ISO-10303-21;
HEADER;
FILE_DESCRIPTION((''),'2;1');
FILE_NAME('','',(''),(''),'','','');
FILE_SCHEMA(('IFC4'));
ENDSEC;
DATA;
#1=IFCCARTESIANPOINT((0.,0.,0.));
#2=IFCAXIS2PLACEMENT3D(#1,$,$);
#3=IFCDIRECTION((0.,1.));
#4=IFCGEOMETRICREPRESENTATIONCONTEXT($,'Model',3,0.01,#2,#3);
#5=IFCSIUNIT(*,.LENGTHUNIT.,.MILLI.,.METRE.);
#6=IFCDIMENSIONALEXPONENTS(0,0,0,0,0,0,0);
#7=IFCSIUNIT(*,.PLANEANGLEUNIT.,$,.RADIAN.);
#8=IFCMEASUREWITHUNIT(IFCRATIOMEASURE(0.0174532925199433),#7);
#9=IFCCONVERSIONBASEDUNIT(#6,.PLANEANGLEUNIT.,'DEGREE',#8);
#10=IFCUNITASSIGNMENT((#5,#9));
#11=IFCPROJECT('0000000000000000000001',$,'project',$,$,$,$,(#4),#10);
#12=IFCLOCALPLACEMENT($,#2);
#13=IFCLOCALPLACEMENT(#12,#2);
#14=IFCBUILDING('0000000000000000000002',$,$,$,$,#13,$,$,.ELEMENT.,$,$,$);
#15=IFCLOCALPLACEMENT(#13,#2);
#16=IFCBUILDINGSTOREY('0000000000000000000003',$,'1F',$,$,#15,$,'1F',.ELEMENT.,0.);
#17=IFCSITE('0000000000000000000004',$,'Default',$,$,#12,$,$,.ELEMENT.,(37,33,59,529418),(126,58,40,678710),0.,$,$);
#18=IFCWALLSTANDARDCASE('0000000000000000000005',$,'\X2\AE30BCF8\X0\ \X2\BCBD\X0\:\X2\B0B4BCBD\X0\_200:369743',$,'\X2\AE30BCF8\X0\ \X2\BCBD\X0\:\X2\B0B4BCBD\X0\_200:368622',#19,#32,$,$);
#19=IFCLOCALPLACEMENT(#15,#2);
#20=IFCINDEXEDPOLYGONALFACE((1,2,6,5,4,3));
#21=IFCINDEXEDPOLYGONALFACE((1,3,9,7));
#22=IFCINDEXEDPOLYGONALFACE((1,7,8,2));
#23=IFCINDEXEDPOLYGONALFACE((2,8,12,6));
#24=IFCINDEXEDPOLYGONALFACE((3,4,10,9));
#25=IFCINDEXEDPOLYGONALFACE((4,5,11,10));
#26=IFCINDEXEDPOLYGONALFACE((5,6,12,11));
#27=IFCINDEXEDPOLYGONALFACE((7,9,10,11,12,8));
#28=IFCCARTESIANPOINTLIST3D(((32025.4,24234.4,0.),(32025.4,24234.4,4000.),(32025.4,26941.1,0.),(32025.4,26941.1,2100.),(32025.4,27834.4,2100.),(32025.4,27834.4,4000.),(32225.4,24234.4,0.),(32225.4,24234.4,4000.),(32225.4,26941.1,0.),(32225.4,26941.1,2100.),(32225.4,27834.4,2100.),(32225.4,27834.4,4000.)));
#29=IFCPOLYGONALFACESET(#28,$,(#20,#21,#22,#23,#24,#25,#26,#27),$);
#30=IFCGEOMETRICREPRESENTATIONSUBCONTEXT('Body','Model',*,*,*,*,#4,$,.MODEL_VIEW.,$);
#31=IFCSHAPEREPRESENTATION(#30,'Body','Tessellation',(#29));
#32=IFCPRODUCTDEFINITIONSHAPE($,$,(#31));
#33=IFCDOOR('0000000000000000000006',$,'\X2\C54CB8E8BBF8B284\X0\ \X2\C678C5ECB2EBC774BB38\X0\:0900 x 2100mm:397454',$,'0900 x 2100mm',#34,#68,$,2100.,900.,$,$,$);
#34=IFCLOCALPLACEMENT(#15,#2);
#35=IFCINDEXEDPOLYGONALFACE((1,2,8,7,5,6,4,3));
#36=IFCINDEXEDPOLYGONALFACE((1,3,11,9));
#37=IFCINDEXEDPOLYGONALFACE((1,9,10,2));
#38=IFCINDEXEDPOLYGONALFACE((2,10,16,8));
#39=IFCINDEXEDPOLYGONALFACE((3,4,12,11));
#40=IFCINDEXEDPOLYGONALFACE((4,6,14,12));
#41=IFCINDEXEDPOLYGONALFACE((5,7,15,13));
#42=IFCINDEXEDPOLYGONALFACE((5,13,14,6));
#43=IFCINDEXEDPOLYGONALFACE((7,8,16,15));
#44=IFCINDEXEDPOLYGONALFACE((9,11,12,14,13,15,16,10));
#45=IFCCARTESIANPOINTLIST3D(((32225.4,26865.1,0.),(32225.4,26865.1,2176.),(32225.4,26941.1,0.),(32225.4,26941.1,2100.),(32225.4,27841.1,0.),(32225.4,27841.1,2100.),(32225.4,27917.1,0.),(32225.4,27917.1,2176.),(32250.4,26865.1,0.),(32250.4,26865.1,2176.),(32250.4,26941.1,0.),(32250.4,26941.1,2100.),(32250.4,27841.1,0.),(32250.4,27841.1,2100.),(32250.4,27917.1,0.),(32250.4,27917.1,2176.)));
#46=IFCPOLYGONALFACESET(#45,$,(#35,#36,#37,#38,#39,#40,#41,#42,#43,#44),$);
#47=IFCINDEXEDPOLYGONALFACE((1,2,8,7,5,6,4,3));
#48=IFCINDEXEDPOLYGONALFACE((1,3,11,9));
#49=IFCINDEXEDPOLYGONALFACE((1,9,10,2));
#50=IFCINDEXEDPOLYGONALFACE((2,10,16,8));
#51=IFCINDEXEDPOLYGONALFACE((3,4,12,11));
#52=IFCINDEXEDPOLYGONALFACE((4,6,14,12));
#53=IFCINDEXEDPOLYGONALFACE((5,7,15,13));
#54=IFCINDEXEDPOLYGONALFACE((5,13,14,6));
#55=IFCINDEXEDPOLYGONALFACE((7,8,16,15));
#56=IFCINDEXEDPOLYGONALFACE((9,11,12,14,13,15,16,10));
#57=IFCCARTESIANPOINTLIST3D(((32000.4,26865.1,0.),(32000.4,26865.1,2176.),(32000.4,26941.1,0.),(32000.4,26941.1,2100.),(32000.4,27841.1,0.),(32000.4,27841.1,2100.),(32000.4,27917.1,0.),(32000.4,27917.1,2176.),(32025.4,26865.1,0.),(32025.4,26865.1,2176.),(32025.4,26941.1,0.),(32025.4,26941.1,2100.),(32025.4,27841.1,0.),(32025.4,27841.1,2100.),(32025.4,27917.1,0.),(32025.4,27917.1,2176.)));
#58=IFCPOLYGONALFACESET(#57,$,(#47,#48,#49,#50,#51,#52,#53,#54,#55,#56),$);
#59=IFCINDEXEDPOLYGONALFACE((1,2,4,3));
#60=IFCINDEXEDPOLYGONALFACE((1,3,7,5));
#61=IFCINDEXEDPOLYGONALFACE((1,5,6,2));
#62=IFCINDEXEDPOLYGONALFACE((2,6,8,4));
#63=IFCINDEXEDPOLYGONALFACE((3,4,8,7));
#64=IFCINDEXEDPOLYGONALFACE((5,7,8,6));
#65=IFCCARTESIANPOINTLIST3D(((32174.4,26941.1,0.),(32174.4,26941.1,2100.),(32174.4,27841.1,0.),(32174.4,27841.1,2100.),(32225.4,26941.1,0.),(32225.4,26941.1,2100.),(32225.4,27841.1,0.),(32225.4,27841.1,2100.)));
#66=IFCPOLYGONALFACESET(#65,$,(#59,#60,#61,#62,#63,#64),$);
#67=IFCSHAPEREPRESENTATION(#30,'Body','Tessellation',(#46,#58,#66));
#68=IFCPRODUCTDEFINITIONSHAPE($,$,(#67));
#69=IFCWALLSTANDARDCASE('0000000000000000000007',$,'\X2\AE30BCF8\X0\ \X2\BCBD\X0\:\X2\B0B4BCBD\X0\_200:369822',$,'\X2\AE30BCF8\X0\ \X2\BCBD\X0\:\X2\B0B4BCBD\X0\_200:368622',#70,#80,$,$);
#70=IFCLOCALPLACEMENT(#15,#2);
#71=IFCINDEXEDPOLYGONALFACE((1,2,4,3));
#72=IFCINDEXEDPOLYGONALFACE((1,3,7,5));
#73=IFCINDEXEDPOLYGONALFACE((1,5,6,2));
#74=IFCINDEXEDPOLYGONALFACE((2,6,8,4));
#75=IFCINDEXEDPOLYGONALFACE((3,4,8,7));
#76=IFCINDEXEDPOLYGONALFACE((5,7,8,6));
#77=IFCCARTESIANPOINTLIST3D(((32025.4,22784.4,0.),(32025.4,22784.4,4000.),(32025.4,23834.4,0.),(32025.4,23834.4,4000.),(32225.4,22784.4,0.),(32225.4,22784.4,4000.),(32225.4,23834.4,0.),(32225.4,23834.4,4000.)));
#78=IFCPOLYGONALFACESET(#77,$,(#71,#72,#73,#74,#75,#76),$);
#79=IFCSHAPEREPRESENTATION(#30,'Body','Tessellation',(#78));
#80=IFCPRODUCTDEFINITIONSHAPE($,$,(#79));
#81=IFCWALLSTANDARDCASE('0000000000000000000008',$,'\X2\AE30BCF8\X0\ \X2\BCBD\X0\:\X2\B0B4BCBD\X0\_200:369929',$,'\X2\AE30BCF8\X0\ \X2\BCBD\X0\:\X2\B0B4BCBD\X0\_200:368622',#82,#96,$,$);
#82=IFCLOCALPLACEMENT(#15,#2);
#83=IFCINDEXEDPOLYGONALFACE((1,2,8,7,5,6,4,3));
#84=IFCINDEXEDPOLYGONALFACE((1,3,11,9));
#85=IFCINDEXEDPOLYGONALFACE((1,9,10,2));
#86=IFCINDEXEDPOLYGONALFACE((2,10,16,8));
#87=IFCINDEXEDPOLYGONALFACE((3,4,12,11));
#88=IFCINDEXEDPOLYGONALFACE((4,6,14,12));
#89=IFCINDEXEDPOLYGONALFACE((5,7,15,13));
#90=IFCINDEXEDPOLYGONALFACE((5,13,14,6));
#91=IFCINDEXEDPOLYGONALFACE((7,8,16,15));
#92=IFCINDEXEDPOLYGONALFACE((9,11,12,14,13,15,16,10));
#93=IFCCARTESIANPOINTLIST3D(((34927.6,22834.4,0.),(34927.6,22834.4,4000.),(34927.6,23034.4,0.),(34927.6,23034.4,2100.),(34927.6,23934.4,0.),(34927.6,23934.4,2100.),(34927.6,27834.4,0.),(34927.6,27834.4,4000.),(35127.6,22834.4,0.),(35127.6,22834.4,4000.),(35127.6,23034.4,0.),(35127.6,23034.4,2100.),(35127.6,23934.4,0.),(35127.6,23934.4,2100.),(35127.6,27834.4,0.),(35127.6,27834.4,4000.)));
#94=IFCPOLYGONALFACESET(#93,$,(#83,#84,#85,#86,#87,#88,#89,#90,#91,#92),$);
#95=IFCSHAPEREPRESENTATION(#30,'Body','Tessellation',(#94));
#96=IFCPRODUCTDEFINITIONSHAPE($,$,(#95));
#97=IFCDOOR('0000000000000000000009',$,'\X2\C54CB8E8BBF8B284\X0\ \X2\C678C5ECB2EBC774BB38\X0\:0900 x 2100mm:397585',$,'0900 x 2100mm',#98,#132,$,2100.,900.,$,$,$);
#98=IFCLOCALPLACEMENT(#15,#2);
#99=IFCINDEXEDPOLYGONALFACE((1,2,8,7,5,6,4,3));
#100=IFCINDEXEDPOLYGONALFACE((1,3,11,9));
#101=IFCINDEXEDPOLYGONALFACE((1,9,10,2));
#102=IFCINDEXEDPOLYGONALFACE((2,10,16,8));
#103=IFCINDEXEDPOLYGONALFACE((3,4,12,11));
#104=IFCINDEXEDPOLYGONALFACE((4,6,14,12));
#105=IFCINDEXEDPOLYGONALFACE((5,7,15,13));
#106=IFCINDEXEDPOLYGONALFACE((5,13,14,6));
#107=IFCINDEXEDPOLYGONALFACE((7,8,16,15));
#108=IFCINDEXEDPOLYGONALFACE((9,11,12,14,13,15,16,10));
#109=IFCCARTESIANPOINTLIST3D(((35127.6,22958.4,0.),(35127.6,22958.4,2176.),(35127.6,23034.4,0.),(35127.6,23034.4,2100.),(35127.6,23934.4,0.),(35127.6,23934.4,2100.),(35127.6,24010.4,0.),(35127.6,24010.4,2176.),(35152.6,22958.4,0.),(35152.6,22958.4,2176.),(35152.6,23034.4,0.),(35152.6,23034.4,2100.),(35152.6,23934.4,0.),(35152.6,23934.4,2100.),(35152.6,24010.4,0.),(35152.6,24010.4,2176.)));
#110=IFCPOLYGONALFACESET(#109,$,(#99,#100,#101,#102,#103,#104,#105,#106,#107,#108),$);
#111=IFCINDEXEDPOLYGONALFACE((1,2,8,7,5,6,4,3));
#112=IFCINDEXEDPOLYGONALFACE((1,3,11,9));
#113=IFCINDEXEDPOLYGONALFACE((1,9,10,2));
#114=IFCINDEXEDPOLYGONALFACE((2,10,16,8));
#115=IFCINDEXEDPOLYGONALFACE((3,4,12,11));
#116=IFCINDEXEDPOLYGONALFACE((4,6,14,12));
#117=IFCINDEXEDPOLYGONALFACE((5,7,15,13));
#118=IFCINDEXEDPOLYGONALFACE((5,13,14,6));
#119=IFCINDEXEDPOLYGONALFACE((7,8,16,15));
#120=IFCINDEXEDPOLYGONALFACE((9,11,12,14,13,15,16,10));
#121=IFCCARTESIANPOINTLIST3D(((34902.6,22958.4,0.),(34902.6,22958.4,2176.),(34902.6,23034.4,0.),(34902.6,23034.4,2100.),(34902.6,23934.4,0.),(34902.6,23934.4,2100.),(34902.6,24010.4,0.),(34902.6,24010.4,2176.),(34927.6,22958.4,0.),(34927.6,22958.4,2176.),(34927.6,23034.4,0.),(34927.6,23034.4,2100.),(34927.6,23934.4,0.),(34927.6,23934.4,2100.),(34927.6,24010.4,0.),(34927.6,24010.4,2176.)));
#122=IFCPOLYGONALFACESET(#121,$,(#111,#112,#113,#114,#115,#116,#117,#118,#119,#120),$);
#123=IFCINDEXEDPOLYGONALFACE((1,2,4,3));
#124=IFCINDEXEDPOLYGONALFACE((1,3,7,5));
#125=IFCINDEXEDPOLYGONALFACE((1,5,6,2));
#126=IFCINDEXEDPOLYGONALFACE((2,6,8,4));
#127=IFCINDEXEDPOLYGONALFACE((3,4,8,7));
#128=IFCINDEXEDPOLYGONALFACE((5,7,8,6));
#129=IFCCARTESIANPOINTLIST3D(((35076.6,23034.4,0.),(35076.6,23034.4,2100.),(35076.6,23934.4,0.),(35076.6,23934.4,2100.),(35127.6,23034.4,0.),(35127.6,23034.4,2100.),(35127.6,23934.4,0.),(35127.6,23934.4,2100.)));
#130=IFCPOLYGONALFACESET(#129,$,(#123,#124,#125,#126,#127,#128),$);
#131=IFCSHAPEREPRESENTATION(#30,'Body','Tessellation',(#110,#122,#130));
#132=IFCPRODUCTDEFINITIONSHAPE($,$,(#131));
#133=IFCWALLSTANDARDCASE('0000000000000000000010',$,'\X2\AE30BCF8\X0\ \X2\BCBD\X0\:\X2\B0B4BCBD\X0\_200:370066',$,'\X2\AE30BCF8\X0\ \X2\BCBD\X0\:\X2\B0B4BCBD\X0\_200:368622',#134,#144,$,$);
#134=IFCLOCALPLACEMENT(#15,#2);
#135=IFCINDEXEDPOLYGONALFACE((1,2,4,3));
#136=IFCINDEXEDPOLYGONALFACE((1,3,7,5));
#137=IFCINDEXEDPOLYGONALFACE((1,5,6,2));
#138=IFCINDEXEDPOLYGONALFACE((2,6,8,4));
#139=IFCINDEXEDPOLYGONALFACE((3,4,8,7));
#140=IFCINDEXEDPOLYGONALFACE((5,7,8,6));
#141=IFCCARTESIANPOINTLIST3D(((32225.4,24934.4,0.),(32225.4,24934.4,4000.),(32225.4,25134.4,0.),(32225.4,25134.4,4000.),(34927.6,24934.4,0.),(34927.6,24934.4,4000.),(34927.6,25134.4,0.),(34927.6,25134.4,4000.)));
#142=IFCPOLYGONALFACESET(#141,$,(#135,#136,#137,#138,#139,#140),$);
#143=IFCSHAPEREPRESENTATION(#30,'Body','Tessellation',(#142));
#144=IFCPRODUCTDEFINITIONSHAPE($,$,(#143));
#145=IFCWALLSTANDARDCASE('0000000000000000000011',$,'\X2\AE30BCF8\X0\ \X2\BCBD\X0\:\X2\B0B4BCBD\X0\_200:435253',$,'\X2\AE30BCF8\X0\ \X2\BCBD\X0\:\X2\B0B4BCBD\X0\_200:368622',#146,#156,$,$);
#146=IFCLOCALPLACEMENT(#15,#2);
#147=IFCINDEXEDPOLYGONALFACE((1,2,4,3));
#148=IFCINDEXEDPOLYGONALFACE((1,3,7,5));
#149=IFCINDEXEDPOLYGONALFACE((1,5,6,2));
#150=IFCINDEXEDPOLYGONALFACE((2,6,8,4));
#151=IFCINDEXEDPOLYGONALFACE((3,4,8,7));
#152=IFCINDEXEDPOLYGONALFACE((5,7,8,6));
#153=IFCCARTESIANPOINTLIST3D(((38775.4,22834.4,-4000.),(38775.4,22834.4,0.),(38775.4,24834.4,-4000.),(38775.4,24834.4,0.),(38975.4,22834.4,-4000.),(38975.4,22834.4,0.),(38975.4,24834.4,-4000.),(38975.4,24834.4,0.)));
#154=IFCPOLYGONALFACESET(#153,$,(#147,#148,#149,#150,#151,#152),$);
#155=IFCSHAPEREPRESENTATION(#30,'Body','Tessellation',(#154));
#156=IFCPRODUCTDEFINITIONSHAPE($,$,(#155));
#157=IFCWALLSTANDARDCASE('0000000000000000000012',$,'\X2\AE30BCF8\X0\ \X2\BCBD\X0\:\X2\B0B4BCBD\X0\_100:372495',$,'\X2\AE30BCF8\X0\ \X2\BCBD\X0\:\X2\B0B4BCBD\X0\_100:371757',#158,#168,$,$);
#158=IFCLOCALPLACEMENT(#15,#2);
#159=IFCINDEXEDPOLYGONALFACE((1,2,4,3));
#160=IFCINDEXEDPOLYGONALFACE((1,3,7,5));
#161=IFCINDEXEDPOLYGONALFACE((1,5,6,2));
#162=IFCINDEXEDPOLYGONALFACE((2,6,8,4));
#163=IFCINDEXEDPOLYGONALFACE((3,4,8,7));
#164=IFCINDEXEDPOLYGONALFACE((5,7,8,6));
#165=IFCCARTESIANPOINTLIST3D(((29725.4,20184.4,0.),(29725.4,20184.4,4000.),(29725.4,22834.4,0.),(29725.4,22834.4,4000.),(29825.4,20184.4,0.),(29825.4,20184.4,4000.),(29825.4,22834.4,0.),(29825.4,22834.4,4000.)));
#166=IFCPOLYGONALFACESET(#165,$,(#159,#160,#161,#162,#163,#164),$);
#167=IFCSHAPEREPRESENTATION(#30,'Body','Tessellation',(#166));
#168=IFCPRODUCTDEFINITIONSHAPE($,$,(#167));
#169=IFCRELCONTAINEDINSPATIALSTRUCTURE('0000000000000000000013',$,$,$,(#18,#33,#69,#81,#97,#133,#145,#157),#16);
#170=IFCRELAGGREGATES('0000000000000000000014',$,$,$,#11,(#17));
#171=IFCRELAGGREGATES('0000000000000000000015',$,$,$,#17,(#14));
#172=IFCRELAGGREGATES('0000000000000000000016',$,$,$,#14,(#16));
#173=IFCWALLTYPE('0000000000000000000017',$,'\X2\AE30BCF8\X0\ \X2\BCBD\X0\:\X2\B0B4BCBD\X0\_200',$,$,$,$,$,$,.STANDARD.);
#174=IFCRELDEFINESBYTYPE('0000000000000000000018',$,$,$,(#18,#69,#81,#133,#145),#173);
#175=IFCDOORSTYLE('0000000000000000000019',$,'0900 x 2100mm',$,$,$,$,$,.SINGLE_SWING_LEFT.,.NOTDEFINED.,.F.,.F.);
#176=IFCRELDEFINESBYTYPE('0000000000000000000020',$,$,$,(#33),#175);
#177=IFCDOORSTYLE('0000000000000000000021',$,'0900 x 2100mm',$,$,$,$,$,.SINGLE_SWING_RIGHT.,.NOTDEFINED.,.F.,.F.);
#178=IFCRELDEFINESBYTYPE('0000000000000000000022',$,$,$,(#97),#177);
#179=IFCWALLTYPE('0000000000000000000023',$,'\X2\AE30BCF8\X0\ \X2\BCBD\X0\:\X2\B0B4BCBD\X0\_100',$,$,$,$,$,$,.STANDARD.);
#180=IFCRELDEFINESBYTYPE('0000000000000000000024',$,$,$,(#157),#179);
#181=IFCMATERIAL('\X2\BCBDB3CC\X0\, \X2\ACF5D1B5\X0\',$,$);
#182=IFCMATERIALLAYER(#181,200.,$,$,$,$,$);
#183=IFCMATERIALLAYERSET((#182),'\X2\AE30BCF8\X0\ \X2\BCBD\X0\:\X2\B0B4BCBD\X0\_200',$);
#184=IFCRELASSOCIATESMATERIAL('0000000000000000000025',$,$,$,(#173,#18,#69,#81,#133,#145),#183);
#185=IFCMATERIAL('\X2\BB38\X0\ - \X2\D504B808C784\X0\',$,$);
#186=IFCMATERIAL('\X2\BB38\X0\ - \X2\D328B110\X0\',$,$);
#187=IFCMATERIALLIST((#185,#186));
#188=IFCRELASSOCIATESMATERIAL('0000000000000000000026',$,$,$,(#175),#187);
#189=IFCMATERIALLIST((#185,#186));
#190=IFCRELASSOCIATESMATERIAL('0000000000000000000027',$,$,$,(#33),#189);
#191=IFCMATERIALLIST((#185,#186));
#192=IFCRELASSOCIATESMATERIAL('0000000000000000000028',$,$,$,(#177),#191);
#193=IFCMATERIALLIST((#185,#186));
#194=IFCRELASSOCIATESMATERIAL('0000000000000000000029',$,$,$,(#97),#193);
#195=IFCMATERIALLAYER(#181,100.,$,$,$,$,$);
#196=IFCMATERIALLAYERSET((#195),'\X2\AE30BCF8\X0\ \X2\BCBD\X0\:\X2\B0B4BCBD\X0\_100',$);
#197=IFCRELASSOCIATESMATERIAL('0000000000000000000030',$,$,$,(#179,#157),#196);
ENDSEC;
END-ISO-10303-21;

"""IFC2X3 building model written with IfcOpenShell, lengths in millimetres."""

from ifc_helpers import new_model, entity, si_unit, converted_unit, direction, frame, frame_2d, origin, place, context, subcontext, project, spatial, polyline, rectangle, outline, extrude, source, transform, mapped, material, material_list, layer, layer_set, layer_usage, type_object, type_shapes, element, fill, save


model = new_model("IFC2X3")

# Units and contexts
model_context = context("Model", 3, precision=0.01, world=origin(), true_north=direction((0.0, 1.0)))
body_context = subcontext(model_context, "Body", "Model", "MODEL_VIEW")
ifc_project = project(units=[si_unit("LENGTHUNIT", "METRE", prefix="MILLI"), converted_unit("PLANEANGLEUNIT", "DEGREE", entity("IfcRatioMeasure", 0.0174532925199433), si_unit("PLANEANGLEUNIT", "RADIAN"), dimensions=[0, 0, 0, 0, 0, 0, 0])], contexts=[model_context])

# Site, building, storey
site_placement = place(None, origin())
site = spatial("IfcSite", under=ifc_project, at=site_placement, Name="Default", CompositionType="ELEMENT", RefLatitude=(37, 33, 59, 529418), RefLongitude=(126, 58, 40, 678710), RefElevation=0.0)
building_placement = place(site_placement, origin())
building = spatial("IfcBuilding", under=site, at=building_placement, CompositionType="ELEMENT")
storey_placement = place(building_placement, origin())
storey = spatial("IfcBuildingStorey", under=building, at=storey_placement, Name="1F", LongName="1F", CompositionType="ELEMENT", Elevation=0.0)

# Wall, opening, door
ifc_material_1 = material(Name="벽돌, 공통")
ifc_layer_1 = layer(ifc_material_1, 200.0)
ifc_layer_set_1 = layer_set([ifc_layer_1], Name="기본 벽:내벽_200")
ifc_layer_usage_1 = layer_usage(ifc_layer_set_1, "AXIS2", "NEGATIVE", 100.0)
wall_type_1 = type_object("IfcWallType", Name="기본 벽:내벽_200", PredefinedType="STANDARD", material=ifc_layer_set_1)
wall_1_placement = place(storey_placement, frame((32125.4, 24234.4, 0.0), z_axis=(0.0, 0.0, 1.0), x_axis=(0.0, 1.0, 0.0)))
wall_1 = element("IfcWallStandardCase", 1, at=wall_1_placement, inside=storey, type_object=wall_type_1, material=ifc_layer_usage_1, Name="기본 벽:내벽_200:369743", ObjectType="기본 벽:내벽_200:368622", context=body_context, shape_type="SweptSolid", body=[
    extrude(rectangle(XDim=3600.0, YDim=200.0, at=frame_2d((1800.0, 0.0), x_axis=(-1.0, 0.0))), origin(), (0.0, 0.0, 1.0), 4000.0),
])
opening_1_placement = place(wall_1_placement, frame((3606.7, 100.0, 0.0)))
opening_1 = element("IfcOpeningElement", 2, at=opening_1_placement, cuts=wall_1, ObjectType="Opening", context=body_context, shape_type="SweptSolid", body=[
    extrude(rectangle(XDim=900.0, YDim=2100.0, at=frame_2d((1050.0, 450.0), x_axis=(0.0, -1.0))), frame((0.0, 0.0, 0.0), z_axis=(0.0, -1.0, 0.0), x_axis=(0.0, 0.0, 1.0)), (0.0, 0.0, 1.0), 200.0),
])
ifc_material_2 = material(Name="문 - 프레임")
ifc_material_3 = material(Name="문 - 패널")
ifc_material_list_1 = material_list([ifc_material_2, ifc_material_3])
ifc_material_list_2 = material_list([ifc_material_2, ifc_material_3])
door_style_1 = type_object("IfcDoorStyle", Name="0900 x 2100mm", ConstructionType="NOTDEFINED", OperationType="SINGLE_SWING_LEFT", ParameterTakesPrecedence=False, Sizeable=False, material=ifc_material_list_2)
shared_shape_1 = source(origin(), body_context, "Body", "SweptSolid", [
    extrude(outline(polyline([(-526.0, -1107.0), (526.0, -1107.0), (526.0, 1069.0), (450.0, 1069.0), (450.0, -1031.0), (-450.0, -1031.0), (-450.0, 1069.0), (-526.0, 1069.0), (-526.0, -1107.0)])), frame((450.0, 225.0, 1069.0), z_axis=(0.0, -1.0, 0.0), x_axis=(-1.0, 0.0, 0.0)), (0.0, 0.0, 1.0), 25.0),
    extrude(outline(polyline([(-1107.0, -526.0), (1069.0, -526.0), (1069.0, -450.0), (-1031.0, -450.0), (-1031.0, 450.0), (1069.0, 450.0), (1069.0, 526.0), (-1107.0, 526.0), (-1107.0, -526.0)])), frame((450.0, 0.0, 1069.0), z_axis=(0.0, -1.0, 0.0), x_axis=(0.0, 0.0, -1.0)), (0.0, 0.0, 1.0), 25.0),
    extrude(rectangle(XDim=900.0, YDim=51.0, at=frame_2d((0.0, 0.0), x_axis=(1.0, 0.0))), frame((450.0, 174.5, 0.0)), (0.0, 0.0, 1.0), 2100.0),
])
type_shapes(door_style_1, [shared_shape_1])
door_1_placement = place(opening_1_placement, frame((0.0, 0.0, 0.0), z_axis=(0.0, 0.0, 1.0), x_axis=(-1.0, 0.0, 0.0)))
door_1 = element("IfcDoor", 3, at=door_1_placement, inside=storey, type_object=door_style_1, material=ifc_material_list_1, Name="알루미늄 외여닫이문:0900 x 2100mm:397454", ObjectType="0900 x 2100mm", OverallHeight=2100.0, OverallWidth=900.0, context=body_context, shape_type="MappedRepresentation", body=[
    mapped(shared_shape_1, transform((0.0, 0.0, 0.0), scale=1.0)),
])
fill(opening_1, door_1)

# Wall
ifc_layer_usage_2 = layer_usage(ifc_layer_set_1, "AXIS2", "NEGATIVE", 100.0)
wall_2_placement = place(storey_placement, frame((32125.4, 22784.4, 0.0), z_axis=(0.0, 0.0, 1.0), x_axis=(0.0, 1.0, 0.0)))
element("IfcWallStandardCase", 4, at=wall_2_placement, inside=storey, type_object=wall_type_1, material=ifc_layer_usage_2, Name="기본 벽:내벽_200:369822", ObjectType="기본 벽:내벽_200:368622", context=body_context, shape_type="SweptSolid", body=[
    extrude(rectangle(XDim=1050.0, YDim=200.0, at=frame_2d((525.0, 0.0), x_axis=(-1.0, 0.0))), origin(), (0.0, 0.0, 1.0), 4000.0),
])

# Wall, opening, door
ifc_layer_usage_3 = layer_usage(ifc_layer_set_1, "AXIS2", "NEGATIVE", 100.0)
wall_3_placement = place(storey_placement, frame((35027.6, 22834.4, 0.0), z_axis=(0.0, 0.0, 1.0), x_axis=(0.0, 1.0, 0.0)))
wall_3 = element("IfcWallStandardCase", 5, at=wall_3_placement, inside=storey, type_object=wall_type_1, material=ifc_layer_usage_3, Name="기본 벽:내벽_200:369929", ObjectType="기본 벽:내벽_200:368622", context=body_context, shape_type="SweptSolid", body=[
    extrude(rectangle(XDim=5000.0, YDim=200.0, at=frame_2d((2500.0, 0.0), x_axis=(-1.0, 0.0))), origin(), (0.0, 0.0, 1.0), 4000.0),
])
opening_2_placement = place(wall_3_placement, frame((1100.0, 100.0, 0.0)))
opening_2 = element("IfcOpeningElement", 6, at=opening_2_placement, cuts=wall_3, ObjectType="Opening", context=body_context, shape_type="SweptSolid", body=[
    extrude(rectangle(XDim=900.0, YDim=2100.0, at=frame_2d((1050.0, 450.0), x_axis=(0.0, 1.0))), frame((0.0, 0.0, 0.0), z_axis=(0.0, -1.0, 0.0), x_axis=(0.0, 0.0, 1.0)), (0.0, 0.0, 1.0), 200.0),
])
ifc_material_list_3 = material_list([ifc_material_2, ifc_material_3])
ifc_material_list_4 = material_list([ifc_material_2, ifc_material_3])
door_style_2 = type_object("IfcDoorStyle", Name="0900 x 2100mm", ConstructionType="NOTDEFINED", OperationType="SINGLE_SWING_RIGHT", ParameterTakesPrecedence=False, Sizeable=False, material=ifc_material_list_4)
shared_shape_2 = source(origin(), body_context, "Body", "SweptSolid", [
    extrude(outline(polyline([(-526.0, -1107.0), (526.0, -1107.0), (526.0, 1069.0), (450.0, 1069.0), (450.0, -1031.0), (-450.0, -1031.0), (-450.0, 1069.0), (-526.0, 1069.0), (-526.0, -1107.0)])), frame((450.0, 200.0, 1069.0), z_axis=(0.0, 1.0, 0.0), x_axis=(1.0, 0.0, 0.0)), (0.0, 0.0, 1.0), 25.0),
    extrude(outline(polyline([(-1107.0, -526.0), (1069.0, -526.0), (1069.0, -450.0), (-1031.0, -450.0), (-1031.0, 450.0), (1069.0, 450.0), (1069.0, 526.0), (-1107.0, 526.0), (-1107.0, -526.0)])), frame((450.0, -25.0, 1069.0), z_axis=(0.0, 1.0, 0.0), x_axis=(0.0, 0.0, -1.0)), (0.0, 0.0, 1.0), 25.0),
    extrude(rectangle(XDim=51.0, YDim=900.0, at=frame_2d((0.0, 0.0), x_axis=(1.0, 0.0))), frame((450.0, 174.5, 0.0), z_axis=(0.0, 0.0, 1.0), x_axis=(0.0, 1.0, 0.0)), (0.0, 0.0, 1.0), 2100.0),
])
type_shapes(door_style_2, [shared_shape_2])
door_2_placement = place(opening_2_placement, frame((0.0, 0.0, 0.0), z_axis=(0.0, 0.0, 1.0), x_axis=(-1.0, 0.0, 0.0)))
door_2 = element("IfcDoor", 7, at=door_2_placement, inside=storey, type_object=door_style_2, material=ifc_material_list_3, Name="알루미늄 외여닫이문:0900 x 2100mm:397585", ObjectType="0900 x 2100mm", OverallHeight=2100.0, OverallWidth=900.0, context=body_context, shape_type="MappedRepresentation", body=[
    mapped(shared_shape_2, transform((0.0, 0.0, 0.0), scale=1.0)),
])
fill(opening_2, door_2)

# Walls
ifc_layer_usage_4 = layer_usage(ifc_layer_set_1, "AXIS2", "NEGATIVE", 100.0)
wall_4_placement = place(storey_placement, frame((34927.6, 25034.4, 0.0), z_axis=(0.0, 0.0, 1.0), x_axis=(-1.0, 0.0, 0.0)))
element("IfcWallStandardCase", 8, at=wall_4_placement, inside=storey, type_object=wall_type_1, material=ifc_layer_usage_4, Name="기본 벽:내벽_200:370066", ObjectType="기본 벽:내벽_200:368622", context=body_context, shape_type="SweptSolid", body=[
    extrude(rectangle(XDim=2702.2, YDim=200.0, at=frame_2d((1351.1, 0.0), x_axis=(-1.0, 0.0))), origin(), (0.0, 0.0, 1.0), 4000.0),
])
ifc_layer_usage_5 = layer_usage(ifc_layer_set_1, "AXIS2", "NEGATIVE", 100.0)
wall_5_placement = place(storey_placement, frame((38875.4, 22834.4, -4000.0), z_axis=(0.0, 0.0, 1.0), x_axis=(0.0, 1.0, 0.0)))
element("IfcWallStandardCase", 9, at=wall_5_placement, inside=storey, type_object=wall_type_1, material=ifc_layer_usage_5, Name="기본 벽:내벽_200:435253", ObjectType="기본 벽:내벽_200:368622", context=body_context, shape_type="SweptSolid", body=[
    extrude(rectangle(XDim=2000.0, YDim=200.0, at=frame_2d((1000.0, 0.0), x_axis=(-1.0, 0.0))), origin(), (0.0, 0.0, 1.0), 4000.0),
])
ifc_layer_2 = layer(ifc_material_1, 100.0)
ifc_layer_set_2 = layer_set([ifc_layer_2], Name="기본 벽:내벽_100")
ifc_layer_usage_6 = layer_usage(ifc_layer_set_2, "AXIS2", "NEGATIVE", 50.0)
wall_type_2 = type_object("IfcWallType", Name="기본 벽:내벽_100", PredefinedType="STANDARD", material=ifc_layer_set_2)
wall_6_placement = place(storey_placement, frame((29775.4, 20184.4, 0.0), z_axis=(0.0, 0.0, 1.0), x_axis=(0.0, 1.0, 0.0)))
element("IfcWallStandardCase", 10, at=wall_6_placement, inside=storey, type_object=wall_type_2, material=ifc_layer_usage_6, Name="기본 벽:내벽_100:372495", ObjectType="기본 벽:내벽_100:371757", context=body_context, shape_type="SweptSolid", body=[
    extrude(rectangle(XDim=2650.0, YDim=100.0, at=frame_2d((1325.0, 0.0), x_axis=(-1.0, 0.0))), origin(), (0.0, 0.0, 1.0), 4000.0),
])

save(model, "model.ifc")
